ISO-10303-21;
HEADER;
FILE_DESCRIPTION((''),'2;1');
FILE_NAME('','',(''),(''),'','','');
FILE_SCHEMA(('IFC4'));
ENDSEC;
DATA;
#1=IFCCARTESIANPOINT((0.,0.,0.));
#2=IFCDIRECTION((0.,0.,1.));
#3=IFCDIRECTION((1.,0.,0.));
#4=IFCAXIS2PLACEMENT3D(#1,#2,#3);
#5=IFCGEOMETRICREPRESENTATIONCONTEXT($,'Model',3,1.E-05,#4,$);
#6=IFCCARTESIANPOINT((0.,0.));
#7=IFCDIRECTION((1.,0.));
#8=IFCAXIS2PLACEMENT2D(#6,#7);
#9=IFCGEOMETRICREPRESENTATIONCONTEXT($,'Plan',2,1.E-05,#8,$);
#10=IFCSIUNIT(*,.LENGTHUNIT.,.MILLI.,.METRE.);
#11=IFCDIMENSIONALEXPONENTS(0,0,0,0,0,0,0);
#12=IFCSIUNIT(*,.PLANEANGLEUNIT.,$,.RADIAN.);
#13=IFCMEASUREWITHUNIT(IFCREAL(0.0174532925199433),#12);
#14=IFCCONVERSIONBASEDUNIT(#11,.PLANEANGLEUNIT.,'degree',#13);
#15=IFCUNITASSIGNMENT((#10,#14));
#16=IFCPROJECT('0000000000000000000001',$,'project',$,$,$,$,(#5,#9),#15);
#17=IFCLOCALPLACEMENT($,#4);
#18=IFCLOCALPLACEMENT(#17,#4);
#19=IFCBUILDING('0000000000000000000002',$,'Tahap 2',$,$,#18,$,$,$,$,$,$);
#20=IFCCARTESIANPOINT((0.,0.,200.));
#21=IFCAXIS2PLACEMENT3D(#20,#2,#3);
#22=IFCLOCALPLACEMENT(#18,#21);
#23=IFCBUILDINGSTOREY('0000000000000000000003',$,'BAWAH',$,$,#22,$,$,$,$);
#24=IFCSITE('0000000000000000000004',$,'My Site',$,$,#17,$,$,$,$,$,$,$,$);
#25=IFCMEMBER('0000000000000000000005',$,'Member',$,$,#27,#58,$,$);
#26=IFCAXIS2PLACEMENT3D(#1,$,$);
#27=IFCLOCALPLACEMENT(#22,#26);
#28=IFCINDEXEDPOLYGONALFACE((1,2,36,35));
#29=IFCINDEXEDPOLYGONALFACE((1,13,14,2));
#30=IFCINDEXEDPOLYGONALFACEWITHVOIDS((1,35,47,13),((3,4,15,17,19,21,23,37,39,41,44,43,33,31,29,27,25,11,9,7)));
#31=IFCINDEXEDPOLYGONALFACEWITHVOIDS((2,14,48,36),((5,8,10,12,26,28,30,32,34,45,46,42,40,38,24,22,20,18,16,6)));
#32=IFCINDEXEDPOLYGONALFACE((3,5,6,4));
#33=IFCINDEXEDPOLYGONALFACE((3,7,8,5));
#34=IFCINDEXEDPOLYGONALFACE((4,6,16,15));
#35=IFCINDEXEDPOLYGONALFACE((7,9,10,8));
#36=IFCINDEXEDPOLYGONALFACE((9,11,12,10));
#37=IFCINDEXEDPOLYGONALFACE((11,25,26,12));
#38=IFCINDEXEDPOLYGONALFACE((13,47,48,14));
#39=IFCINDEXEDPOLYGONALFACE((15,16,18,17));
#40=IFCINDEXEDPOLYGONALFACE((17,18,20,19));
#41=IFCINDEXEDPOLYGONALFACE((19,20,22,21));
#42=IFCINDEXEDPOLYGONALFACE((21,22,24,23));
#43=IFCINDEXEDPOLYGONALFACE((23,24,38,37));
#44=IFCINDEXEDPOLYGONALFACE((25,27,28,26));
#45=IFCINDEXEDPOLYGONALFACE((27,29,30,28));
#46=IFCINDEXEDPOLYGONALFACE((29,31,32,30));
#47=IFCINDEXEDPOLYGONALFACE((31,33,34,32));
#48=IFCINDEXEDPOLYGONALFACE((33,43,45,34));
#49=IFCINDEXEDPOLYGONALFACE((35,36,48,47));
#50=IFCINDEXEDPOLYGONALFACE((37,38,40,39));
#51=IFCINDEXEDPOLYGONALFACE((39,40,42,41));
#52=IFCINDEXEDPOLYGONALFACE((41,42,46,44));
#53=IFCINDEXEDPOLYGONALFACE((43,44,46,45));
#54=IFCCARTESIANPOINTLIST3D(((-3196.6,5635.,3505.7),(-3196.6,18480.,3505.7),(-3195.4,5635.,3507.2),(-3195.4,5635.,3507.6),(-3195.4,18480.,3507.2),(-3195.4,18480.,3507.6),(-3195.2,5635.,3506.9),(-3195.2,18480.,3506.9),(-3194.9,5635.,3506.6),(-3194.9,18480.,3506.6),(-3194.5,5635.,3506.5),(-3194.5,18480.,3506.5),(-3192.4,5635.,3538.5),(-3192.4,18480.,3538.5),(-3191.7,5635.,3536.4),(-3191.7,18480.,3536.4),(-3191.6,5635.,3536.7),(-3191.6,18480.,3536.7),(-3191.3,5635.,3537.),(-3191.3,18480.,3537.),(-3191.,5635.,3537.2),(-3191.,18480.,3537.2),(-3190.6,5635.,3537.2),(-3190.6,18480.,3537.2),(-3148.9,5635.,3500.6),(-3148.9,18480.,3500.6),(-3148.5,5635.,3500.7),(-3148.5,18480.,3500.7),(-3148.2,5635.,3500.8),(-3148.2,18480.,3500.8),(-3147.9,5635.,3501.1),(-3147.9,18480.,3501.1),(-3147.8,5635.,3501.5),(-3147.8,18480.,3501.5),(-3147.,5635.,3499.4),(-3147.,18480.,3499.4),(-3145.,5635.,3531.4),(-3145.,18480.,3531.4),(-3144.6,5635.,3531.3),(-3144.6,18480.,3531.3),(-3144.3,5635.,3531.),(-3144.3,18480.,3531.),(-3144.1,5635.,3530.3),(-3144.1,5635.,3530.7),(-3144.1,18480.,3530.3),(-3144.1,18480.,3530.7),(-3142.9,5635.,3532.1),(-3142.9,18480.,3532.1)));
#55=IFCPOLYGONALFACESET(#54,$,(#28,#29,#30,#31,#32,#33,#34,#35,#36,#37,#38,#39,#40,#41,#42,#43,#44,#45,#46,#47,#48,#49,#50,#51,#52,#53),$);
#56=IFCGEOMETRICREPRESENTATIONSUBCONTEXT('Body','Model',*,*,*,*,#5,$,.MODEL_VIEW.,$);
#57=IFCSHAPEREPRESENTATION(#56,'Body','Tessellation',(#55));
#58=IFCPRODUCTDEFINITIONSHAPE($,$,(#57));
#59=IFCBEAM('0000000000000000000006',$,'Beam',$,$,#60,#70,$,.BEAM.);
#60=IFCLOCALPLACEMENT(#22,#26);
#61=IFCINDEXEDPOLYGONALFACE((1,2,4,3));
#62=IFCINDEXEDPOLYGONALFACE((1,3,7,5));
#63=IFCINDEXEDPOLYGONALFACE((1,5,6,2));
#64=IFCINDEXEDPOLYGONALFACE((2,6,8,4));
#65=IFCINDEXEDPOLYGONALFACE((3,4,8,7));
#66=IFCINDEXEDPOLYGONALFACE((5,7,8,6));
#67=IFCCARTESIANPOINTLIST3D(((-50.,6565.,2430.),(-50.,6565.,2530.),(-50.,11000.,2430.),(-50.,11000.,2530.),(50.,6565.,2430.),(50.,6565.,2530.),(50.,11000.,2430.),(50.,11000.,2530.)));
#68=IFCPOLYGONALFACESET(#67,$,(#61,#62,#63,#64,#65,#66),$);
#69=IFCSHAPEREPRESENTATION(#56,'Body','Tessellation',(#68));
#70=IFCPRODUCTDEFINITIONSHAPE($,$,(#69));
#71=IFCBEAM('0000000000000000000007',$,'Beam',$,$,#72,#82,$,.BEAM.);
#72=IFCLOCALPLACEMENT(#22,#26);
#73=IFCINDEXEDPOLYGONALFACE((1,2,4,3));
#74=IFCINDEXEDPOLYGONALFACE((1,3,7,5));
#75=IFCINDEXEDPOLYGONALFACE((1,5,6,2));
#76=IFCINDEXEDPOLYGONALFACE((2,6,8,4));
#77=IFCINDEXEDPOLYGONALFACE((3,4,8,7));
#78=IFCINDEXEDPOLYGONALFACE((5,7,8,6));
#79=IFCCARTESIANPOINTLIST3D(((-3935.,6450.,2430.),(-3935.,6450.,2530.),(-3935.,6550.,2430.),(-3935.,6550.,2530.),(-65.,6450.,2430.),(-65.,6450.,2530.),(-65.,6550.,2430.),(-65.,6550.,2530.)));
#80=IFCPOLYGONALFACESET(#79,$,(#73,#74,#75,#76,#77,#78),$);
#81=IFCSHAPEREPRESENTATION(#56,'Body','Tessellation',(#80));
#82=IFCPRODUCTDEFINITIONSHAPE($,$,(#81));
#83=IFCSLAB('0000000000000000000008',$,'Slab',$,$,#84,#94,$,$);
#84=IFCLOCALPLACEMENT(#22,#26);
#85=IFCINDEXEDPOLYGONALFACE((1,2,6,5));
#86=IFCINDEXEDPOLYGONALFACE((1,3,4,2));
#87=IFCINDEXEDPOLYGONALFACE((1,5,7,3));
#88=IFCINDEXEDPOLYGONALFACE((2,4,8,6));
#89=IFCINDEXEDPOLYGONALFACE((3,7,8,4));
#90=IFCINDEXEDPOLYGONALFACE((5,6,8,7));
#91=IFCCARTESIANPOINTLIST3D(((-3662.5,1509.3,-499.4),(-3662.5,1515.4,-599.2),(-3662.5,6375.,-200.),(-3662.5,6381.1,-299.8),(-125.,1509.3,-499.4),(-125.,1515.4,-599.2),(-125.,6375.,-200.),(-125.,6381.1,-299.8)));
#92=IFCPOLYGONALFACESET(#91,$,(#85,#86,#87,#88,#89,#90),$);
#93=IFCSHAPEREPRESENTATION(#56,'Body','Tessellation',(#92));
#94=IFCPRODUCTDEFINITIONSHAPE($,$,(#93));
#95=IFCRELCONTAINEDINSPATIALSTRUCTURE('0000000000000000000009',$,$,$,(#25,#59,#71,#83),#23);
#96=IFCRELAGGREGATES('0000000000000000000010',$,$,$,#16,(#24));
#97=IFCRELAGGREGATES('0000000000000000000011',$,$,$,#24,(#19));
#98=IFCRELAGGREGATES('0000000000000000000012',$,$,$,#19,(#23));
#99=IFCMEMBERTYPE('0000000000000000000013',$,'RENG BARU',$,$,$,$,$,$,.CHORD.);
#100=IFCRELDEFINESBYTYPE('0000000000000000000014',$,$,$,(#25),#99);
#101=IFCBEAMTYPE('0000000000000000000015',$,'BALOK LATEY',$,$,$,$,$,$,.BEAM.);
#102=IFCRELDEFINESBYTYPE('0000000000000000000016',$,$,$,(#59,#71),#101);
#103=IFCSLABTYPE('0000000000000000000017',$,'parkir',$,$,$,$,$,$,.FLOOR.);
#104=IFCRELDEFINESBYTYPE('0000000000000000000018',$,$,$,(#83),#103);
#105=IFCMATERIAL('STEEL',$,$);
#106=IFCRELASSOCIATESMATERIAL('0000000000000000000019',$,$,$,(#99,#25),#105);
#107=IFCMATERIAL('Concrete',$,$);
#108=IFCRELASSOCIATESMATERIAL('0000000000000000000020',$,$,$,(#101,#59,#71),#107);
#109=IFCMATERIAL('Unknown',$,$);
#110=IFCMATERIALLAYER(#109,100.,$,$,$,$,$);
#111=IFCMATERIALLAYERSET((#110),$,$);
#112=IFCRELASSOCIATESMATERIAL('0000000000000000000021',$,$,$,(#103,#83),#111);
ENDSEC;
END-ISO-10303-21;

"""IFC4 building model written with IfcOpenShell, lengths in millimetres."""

from ifc_helpers import new_model, entity, si_unit, converted_unit, frame, origin_with_axes, origin_2d_with_axis, place, context, subcontext, project, spatial, indexed_curve, rectangle, hollow_rectangle, outline, extrude, material, layer, layer_set, layer_usage, material_profile, profile_set, profile_usage, type_object, element, save


model = new_model("IFC4")

# Units and contexts
model_context = context("Model", 3, precision=1e-05, world=origin_with_axes())
plan_context = context("Plan", 2, precision=1e-05, world=origin_2d_with_axis())
body_context = subcontext(model_context, "Body", "Model", "MODEL_VIEW")
ifc_project = project(units=[si_unit("LENGTHUNIT", "METRE", prefix="MILLI"), converted_unit("PLANEANGLEUNIT", "degree", entity("IfcReal", 0.0174532925199433), si_unit("PLANEANGLEUNIT", "RADIAN"), dimensions=[0, 0, 0, 0, 0, 0, 0])], contexts=[model_context, plan_context])

# Site, building, storey
site_placement = place(None, origin_with_axes())
site = spatial("IfcSite", under=ifc_project, at=site_placement, Name="My Site")
building_placement = place(site_placement, origin_with_axes())
building = spatial("IfcBuilding", under=site, at=building_placement, Name="Tahap 2")
storey_placement = place(building_placement, frame((0.0, 0.0, 200.0), z_axis=(0.0, 0.0, 1.0), x_axis=(1.0, 0.0, 0.0)))
storey = spatial("IfcBuildingStorey", under=building, at=storey_placement, Name="BAWAH")

# Shared definitions
ifc_material_1 = material(Name="Unknown")

# Shared definitions
ifc_material_2 = material(Name="Concrete")

# Shared definitions
ifc_material_3 = material(Name="STEEL")

# Member
ifc_material_profile_1 = material_profile(ifc_material_3, hollow_rectangle(XDim=50.0, YDim=33.0, WallThickness=1.0, InnerFilletRadius=1.0, OuterFilletRadius=0.0, kind="CURVE"))
ifc_profile_set_1 = profile_set([ifc_material_profile_1])
member_type_1 = type_object("IfcMemberType", Name="RENG BARU", PredefinedType="CHORD", material=ifc_profile_set_1)
ifc_profile_usage_1 = profile_usage(ifc_profile_set_1, cardinal=3)
member_1_placement = place(storey_placement, frame((-3147.0, 5635.0, 3499.4), z_axis=(0.0, 1.0, 0.0), x_axis=(-0.991894, 0.0, 0.127065)))
element("IfcMember", 1, at=member_1_placement, inside=storey, type_object=member_type_1, material=ifc_profile_usage_1, Name="Member", context=body_context, shape_type="SweptSolid", body=[
    extrude(hollow_rectangle(XDim=50.0, YDim=33.0, WallThickness=1.0, InnerFilletRadius=1.0, OuterFilletRadius=0.0, kind="CURVE"), frame((25.0, 16.5, 0.0), z_axis=(0.0, 0.0, 1.0), x_axis=(1.0, 0.0, 0.0)), (0.0, 0.0, 1.0), 12845.0),
])

# Beams
ifc_material_profile_2 = material_profile(ifc_material_2, rectangle(XDim=100.0, YDim=100.0))
ifc_profile_set_2 = profile_set([ifc_material_profile_2])
ifc_profile_usage_2 = profile_usage(ifc_profile_set_2, cardinal=2)
beam_type_1 = type_object("IfcBeamType", Name="BALOK LATEY", PredefinedType="BEAM", material=ifc_profile_set_2)
beam_1_placement = place(storey_placement, frame((0.0, 6565.0, 2430.0), z_axis=(0.0, 1.0, 0.0), x_axis=(-1.0, 0.0, 0.0)))
element("IfcBeam", 2, at=beam_1_placement, inside=storey, type_object=beam_type_1, material=ifc_profile_usage_2, Name="Beam", PredefinedType="BEAM", context=body_context, shape_type="SweptSolid", body=[
    extrude(rectangle(XDim=100.0, YDim=100.0), frame((0.0, 50.0, 0.0), z_axis=(0.0, 0.0, 1.0), x_axis=(1.0, 0.0, 0.0)), (0.0, 0.0, 1.0), 4435.0),
])
ifc_profile_usage_3 = profile_usage(ifc_profile_set_2, cardinal=2)
beam_2_placement = place(storey_placement, frame((-3935.0, 6500.0, 2430.0), z_axis=(1.0, 0.0, 0.000001), x_axis=(0.0, 1.0, 0.0)))
element("IfcBeam", 3, at=beam_2_placement, inside=storey, type_object=beam_type_1, material=ifc_profile_usage_3, Name="Beam", PredefinedType="BEAM", context=body_context, shape_type="SweptSolid", body=[
    extrude(rectangle(XDim=100.0, YDim=100.0), frame((0.0, 50.0, 0.0), z_axis=(0.0, 0.0, 1.0), x_axis=(1.0, 0.0, 0.0)), (0.0, 0.0, 1.0), 3870.0),
])

# Slab
ifc_layer_1 = layer(ifc_material_1, 100.0)
ifc_layer_set_1 = layer_set([ifc_layer_1])
ifc_layer_usage_1 = layer_usage(ifc_layer_set_1, "AXIS3", "POSITIVE", -100.0)
slab_type = type_object("IfcSlabType", Name="parkir", PredefinedType="FLOOR", material=ifc_layer_set_1)
slab_placement = place(storey_placement, frame((-125.0, 6375.0, -200.0), z_axis=(0.0, -0.061422, 0.998112), x_axis=(1.0, 0.0, 0.0)))
element("IfcSlab", 4, at=slab_placement, inside=storey, type_object=slab_type, material=ifc_layer_usage_1, Name="Slab", context=body_context, shape_type="SweptSolid", body=[
    extrude(outline(indexed_curve([(0.0, -4874.9), (-3537.5, -4874.9), (-3537.5, 0.0), (0.0, 0.0), (0.0, -4874.9)])), frame((0.0, 0.0, -100.0), z_axis=(0.0, 0.0, 1.0), x_axis=(1.0, 0.0, 0.0)), (0.0, 0.0, 1.0), 100.0),
])

save(model, "model.ifc")
